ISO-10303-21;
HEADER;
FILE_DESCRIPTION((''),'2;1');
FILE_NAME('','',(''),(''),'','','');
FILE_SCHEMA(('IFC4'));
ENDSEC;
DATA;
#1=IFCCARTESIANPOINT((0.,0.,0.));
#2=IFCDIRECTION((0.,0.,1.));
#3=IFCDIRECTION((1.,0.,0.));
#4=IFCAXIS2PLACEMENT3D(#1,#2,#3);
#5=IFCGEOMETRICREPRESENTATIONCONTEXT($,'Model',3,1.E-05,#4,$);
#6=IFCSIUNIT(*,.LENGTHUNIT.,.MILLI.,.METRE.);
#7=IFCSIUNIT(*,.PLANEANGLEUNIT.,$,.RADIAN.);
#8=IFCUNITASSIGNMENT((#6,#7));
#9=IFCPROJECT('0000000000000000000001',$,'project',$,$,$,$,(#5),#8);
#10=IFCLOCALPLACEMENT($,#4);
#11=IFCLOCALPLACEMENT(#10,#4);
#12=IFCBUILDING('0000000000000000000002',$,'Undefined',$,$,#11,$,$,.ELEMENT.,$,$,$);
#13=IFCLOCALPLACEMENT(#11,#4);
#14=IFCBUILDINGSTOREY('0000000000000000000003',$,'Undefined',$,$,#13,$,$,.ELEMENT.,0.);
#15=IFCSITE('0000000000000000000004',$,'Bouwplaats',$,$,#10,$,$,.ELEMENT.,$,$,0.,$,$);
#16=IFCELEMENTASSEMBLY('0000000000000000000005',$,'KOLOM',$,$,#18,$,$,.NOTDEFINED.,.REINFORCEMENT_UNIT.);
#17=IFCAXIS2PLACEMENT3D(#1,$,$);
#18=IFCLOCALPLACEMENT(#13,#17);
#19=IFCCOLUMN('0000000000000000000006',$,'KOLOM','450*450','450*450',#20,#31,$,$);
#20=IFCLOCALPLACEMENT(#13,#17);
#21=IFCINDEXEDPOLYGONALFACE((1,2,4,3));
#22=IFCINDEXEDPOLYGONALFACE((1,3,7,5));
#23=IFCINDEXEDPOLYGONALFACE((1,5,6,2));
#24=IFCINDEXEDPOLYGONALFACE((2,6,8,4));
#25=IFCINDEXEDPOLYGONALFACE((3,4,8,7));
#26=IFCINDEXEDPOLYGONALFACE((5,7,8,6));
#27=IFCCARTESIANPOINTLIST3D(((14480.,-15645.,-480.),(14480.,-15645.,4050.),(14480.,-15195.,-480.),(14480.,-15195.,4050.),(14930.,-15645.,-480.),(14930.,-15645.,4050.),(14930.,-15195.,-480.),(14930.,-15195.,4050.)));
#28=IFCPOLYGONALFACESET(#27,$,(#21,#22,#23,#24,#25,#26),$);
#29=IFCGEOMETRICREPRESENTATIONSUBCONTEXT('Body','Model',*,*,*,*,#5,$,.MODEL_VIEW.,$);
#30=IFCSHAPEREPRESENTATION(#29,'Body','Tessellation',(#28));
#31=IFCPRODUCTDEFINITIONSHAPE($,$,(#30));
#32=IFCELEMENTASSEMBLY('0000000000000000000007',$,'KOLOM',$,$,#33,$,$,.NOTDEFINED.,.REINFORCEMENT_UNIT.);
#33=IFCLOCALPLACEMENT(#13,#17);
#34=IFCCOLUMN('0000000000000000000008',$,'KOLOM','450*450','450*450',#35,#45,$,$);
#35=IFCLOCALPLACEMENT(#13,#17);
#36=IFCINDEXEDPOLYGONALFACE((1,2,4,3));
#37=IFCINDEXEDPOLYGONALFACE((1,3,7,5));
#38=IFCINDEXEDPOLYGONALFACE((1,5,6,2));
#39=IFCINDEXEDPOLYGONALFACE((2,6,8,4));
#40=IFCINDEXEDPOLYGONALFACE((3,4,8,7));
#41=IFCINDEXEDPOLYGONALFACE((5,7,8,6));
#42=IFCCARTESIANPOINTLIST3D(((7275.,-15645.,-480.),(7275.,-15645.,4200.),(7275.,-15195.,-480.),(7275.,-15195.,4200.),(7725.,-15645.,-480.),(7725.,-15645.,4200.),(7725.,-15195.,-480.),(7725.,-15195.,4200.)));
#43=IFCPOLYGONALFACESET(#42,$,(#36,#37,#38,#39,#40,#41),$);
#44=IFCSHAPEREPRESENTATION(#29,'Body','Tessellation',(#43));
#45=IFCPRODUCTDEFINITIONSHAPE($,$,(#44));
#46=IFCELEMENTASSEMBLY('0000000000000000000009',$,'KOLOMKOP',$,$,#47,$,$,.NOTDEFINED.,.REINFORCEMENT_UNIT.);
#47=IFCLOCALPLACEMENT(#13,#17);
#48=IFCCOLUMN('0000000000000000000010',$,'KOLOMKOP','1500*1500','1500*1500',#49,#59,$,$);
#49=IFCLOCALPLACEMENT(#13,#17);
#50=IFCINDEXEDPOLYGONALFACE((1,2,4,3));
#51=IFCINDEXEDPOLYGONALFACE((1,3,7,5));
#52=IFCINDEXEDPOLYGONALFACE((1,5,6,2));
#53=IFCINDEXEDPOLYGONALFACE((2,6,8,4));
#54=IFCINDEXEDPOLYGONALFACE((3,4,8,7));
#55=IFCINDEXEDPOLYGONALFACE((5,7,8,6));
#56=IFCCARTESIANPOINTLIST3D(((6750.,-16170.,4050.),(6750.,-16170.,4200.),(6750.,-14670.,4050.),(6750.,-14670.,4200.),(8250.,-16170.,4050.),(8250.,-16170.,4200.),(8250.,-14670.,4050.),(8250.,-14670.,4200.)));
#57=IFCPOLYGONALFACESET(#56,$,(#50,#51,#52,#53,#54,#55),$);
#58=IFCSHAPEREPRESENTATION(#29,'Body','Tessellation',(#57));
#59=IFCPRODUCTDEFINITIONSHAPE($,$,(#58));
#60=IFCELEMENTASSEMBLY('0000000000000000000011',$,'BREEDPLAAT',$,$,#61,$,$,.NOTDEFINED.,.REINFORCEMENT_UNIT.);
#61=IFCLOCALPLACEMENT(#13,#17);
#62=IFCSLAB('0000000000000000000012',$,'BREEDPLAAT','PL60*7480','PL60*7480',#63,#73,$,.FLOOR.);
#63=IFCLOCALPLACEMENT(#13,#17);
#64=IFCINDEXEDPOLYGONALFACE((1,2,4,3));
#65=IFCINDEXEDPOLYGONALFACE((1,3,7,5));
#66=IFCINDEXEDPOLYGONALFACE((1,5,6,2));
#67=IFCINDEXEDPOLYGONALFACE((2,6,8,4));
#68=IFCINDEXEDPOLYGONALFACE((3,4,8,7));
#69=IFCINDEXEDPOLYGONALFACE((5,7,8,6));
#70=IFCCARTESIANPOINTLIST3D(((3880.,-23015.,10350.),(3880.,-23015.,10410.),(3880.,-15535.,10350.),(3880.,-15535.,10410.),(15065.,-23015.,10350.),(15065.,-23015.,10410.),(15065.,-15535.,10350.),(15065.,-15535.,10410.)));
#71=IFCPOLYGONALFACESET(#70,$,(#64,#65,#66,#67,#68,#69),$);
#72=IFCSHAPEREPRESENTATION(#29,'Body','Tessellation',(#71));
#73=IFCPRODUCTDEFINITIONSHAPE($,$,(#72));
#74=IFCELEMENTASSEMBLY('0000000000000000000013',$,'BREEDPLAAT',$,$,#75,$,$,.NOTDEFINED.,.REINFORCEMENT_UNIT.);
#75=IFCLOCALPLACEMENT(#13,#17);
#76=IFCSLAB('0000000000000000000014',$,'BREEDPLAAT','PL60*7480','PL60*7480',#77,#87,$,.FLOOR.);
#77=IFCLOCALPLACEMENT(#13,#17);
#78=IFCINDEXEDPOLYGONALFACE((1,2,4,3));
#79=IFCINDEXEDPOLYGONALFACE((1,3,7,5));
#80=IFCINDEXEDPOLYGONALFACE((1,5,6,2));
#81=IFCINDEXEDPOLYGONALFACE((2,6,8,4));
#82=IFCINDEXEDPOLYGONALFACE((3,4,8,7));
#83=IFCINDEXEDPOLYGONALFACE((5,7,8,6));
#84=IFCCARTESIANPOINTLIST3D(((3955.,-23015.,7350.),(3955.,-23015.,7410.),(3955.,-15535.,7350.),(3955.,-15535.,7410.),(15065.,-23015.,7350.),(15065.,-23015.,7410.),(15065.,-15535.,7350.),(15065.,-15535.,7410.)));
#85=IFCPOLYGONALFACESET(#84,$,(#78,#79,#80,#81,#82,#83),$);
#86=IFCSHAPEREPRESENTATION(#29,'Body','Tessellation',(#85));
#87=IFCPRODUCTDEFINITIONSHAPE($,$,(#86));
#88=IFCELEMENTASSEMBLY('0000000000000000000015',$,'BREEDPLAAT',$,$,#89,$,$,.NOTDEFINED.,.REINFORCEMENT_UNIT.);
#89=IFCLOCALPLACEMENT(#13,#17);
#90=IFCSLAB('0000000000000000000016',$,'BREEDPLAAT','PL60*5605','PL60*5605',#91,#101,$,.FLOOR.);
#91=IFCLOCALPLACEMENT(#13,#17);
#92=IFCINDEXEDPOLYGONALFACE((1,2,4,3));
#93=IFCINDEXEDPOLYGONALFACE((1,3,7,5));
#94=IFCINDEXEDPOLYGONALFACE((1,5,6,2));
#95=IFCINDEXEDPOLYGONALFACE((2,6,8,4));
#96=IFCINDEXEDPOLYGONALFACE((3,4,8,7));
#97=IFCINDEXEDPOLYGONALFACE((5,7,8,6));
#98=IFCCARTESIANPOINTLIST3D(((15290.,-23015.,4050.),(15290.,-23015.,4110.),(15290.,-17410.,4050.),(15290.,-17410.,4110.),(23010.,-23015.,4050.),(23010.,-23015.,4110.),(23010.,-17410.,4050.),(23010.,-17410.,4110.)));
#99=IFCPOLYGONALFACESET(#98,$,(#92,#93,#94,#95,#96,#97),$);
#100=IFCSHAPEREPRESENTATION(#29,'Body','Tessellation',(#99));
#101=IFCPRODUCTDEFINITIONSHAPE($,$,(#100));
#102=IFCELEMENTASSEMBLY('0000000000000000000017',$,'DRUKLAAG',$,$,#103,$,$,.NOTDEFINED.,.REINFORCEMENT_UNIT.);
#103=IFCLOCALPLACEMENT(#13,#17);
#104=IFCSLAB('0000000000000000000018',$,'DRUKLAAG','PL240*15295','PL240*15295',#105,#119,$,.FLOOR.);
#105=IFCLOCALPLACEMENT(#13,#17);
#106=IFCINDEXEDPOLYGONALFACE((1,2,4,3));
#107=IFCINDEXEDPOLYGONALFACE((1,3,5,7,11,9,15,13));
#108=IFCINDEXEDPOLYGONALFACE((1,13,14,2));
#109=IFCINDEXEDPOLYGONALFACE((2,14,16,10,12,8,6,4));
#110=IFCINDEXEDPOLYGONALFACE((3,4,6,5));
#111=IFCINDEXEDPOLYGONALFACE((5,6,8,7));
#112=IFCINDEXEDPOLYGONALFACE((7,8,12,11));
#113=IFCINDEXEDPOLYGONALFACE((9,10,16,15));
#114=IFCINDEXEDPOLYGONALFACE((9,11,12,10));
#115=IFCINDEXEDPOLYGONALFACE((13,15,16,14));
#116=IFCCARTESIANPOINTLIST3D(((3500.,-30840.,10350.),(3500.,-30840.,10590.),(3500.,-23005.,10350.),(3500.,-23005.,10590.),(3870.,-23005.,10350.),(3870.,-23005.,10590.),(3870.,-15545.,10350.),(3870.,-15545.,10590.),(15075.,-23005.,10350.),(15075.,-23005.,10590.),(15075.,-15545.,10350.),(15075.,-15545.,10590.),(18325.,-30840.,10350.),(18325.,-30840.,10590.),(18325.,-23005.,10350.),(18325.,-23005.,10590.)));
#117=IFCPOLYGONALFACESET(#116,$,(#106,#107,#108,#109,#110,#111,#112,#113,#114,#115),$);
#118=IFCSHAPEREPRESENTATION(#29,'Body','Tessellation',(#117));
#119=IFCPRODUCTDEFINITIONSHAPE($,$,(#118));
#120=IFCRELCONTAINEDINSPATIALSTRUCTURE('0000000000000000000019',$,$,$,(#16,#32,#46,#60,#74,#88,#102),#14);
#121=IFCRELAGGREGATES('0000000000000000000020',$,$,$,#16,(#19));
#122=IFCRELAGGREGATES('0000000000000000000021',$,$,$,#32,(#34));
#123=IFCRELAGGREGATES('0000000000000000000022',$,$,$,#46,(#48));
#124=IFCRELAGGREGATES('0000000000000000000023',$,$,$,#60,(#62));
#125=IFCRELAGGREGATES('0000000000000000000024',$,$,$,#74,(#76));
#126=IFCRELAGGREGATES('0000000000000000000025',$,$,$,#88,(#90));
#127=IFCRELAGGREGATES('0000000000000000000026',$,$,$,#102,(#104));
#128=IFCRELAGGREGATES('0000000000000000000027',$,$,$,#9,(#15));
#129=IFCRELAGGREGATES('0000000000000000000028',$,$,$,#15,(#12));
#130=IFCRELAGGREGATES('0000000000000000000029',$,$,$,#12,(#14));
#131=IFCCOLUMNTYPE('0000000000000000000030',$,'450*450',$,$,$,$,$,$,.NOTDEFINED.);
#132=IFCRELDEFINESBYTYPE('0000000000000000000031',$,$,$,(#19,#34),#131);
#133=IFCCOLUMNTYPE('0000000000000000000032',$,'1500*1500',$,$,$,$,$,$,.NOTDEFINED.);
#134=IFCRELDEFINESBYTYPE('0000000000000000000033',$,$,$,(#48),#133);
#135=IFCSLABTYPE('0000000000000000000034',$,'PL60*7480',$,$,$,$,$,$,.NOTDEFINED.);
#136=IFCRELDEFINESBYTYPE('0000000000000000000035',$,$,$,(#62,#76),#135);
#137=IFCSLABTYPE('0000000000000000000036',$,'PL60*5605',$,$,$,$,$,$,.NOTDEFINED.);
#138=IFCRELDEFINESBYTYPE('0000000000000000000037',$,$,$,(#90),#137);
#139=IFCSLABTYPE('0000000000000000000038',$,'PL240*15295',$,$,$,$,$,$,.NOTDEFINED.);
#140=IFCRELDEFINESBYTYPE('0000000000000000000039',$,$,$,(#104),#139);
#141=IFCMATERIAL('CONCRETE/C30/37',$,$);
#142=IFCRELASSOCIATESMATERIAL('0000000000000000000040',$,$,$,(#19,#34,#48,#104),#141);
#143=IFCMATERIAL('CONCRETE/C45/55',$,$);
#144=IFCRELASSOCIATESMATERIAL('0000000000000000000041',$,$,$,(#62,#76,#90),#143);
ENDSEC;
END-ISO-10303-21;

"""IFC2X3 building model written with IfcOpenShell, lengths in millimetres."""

from ifc_helpers import new_model, si_unit, frame, origin_with_axes, origin_2d_with_axis, place, context, subcontext, project, spatial, polyline, rectangle, outline, extrude, material, type_object, element, aggregate, save


model = new_model("IFC2X3")

# Units and contexts
model_context = context("Model", 3, precision=1e-05, world=origin_with_axes())
body_context = subcontext(model_context, "Body", "Model", "MODEL_VIEW")
ifc_project = project(units=[si_unit("LENGTHUNIT", "METRE", prefix="MILLI"), si_unit("PLANEANGLEUNIT", "RADIAN")], contexts=[model_context])

# Site, building, storey
site_placement = place(None, origin_with_axes())
site = spatial("IfcSite", under=ifc_project, at=site_placement, Name="Bouwplaats", CompositionType="ELEMENT", RefElevation=0.0)
building_placement = place(site_placement, origin_with_axes())
building = spatial("IfcBuilding", under=site, at=building_placement, Name="Undefined", CompositionType="ELEMENT")
storey_placement = place(building_placement, origin_with_axes())
storey = spatial("IfcBuildingStorey", under=building, at=storey_placement, Name="Undefined", CompositionType="ELEMENT", Elevation=0.0)

# Shared definitions
ifc_material_1 = material(Name="CONCRETE/C30/37")

# Element assemblies, columns
assembly_1_placement = place(storey_placement, origin_with_axes())
assembly_1 = element("IfcElementAssembly", 1, at=assembly_1_placement, inside=storey, Name="KOLOM", AssemblyPlace="NOTDEFINED", PredefinedType="REINFORCEMENT_UNIT")
column_type_1 = type_object("IfcColumnType", Name="450*450", PredefinedType="NOTDEFINED")
column_1_placement = place(assembly_1_placement, frame((14705.0, -15420.0, -480.0), z_axis=(0.0, 0.0, 1.0), x_axis=(0.0, 1.0, 0.0)))
column_1 = element("IfcColumn", 2, at=column_1_placement, type_object=column_type_1, material=ifc_material_1, Name="KOLOM", Description="450*450", ObjectType="450*450", context=body_context, shape_type="SweptSolid", body=[
    extrude(rectangle(XDim=450.0, YDim=450.0, at=origin_2d_with_axis()), frame((0.0, 0.0, 4530.0), z_axis=(0.0, 0.0, -1.0), x_axis=(0.0, 1.0, 0.0)), (0.0, 0.0, 1.0), 4530.0),
])
aggregate(assembly_1, [column_1])
assembly_2_placement = place(storey_placement, origin_with_axes())
assembly_2 = element("IfcElementAssembly", 3, at=assembly_2_placement, inside=storey, Name="KOLOM", AssemblyPlace="NOTDEFINED", PredefinedType="REINFORCEMENT_UNIT")
column_2_placement = place(assembly_2_placement, frame((7500.0, -15420.0, -480.0), z_axis=(0.0, 0.0, 1.0), x_axis=(0.0, 1.0, 0.0)))
column_2 = element("IfcColumn", 4, at=column_2_placement, type_object=column_type_1, material=ifc_material_1, Name="KOLOM", Description="450*450", ObjectType="450*450", context=body_context, shape_type="SweptSolid", body=[
    extrude(rectangle(XDim=450.0, YDim=450.0, at=origin_2d_with_axis()), frame((0.0, 0.0, 4680.0), z_axis=(0.0, 0.0, -1.0), x_axis=(0.0, 1.0, 0.0)), (0.0, 0.0, 1.0), 4680.0),
])
aggregate(assembly_2, [column_2])
assembly_3_placement = place(storey_placement, origin_with_axes())
assembly_3 = element("IfcElementAssembly", 5, at=assembly_3_placement, inside=storey, Name="KOLOMKOP", AssemblyPlace="NOTDEFINED", PredefinedType="REINFORCEMENT_UNIT")
column_type_2 = type_object("IfcColumnType", Name="1500*1500", PredefinedType="NOTDEFINED")
column_3_placement = place(assembly_3_placement, frame((7500.0, -15420.0, 4050.0), z_axis=(0.0, 0.0, 1.0), x_axis=(0.0, 1.0, 0.0)))
column_3 = element("IfcColumn", 6, at=column_3_placement, type_object=column_type_2, material=ifc_material_1, Name="KOLOMKOP", Description="1500*1500", ObjectType="1500*1500", context=body_context, shape_type="SweptSolid", body=[
    extrude(rectangle(XDim=1500.0, YDim=1500.0, at=origin_2d_with_axis()), frame((0.0, 0.0, 150.0), z_axis=(0.0, 0.0, -1.0), x_axis=(0.0, 1.0, 0.0)), (0.0, 0.0, 1.0), 150.0),
])
aggregate(assembly_3, [column_3])

# Element assemblies, slabs
assembly_4_placement = place(storey_placement, origin_with_axes())
assembly_4 = element("IfcElementAssembly", 7, at=assembly_4_placement, inside=storey, Name="BREEDPLAAT", AssemblyPlace="NOTDEFINED", PredefinedType="REINFORCEMENT_UNIT")
ifc_material_2 = material(Name="CONCRETE/C45/55")
slab_type_1 = type_object("IfcSlabType", Name="PL60*7480", PredefinedType="NOTDEFINED")
slab_1_placement = place(assembly_4_placement, frame((15065.0, -15535.0, 10380.0), z_axis=(0.0, 0.0, 1.0), x_axis=(-1.0, 0.0, 0.0)))
slab_1 = element("IfcSlab", 8, at=slab_1_placement, type_object=slab_type_1, material=ifc_material_2, Name="BREEDPLAAT", Description="PL60*7480", ObjectType="PL60*7480", PredefinedType="FLOOR", context=body_context, shape_type="SweptSolid", body=[
    extrude(outline(polyline([(0.0, 0.0), (11185.0, 0.0), (11185.0, 7480.0), (0.0, 7480.0), (0.0, 0.0)])), frame((0.0, 0.0, -30.0), z_axis=(0.0, 0.0, 1.0), x_axis=(1.0, 0.0, 0.0)), (0.0, 0.0, 1.0), 60.0),
])
aggregate(assembly_4, [slab_1])
assembly_5_placement = place(storey_placement, origin_with_axes())
assembly_5 = element("IfcElementAssembly", 9, at=assembly_5_placement, inside=storey, Name="BREEDPLAAT", AssemblyPlace="NOTDEFINED", PredefinedType="REINFORCEMENT_UNIT")
slab_2_placement = place(assembly_5_placement, frame((15065.0, -15535.0, 7380.0), z_axis=(0.0, 0.0, 1.0), x_axis=(-1.0, 0.0, 0.0)))
slab_2 = element("IfcSlab", 10, at=slab_2_placement, type_object=slab_type_1, material=ifc_material_2, Name="BREEDPLAAT", Description="PL60*7480", ObjectType="PL60*7480", PredefinedType="FLOOR", context=body_context, shape_type="SweptSolid", body=[
    extrude(outline(polyline([(0.0, 0.0), (11110.0, 0.0), (11110.0, 7480.0), (0.0, 7480.0), (0.0, 0.0)])), frame((0.0, 0.0, -30.0), z_axis=(0.0, 0.0, 1.0), x_axis=(1.0, 0.0, 0.0)), (0.0, 0.0, 1.0), 60.0),
])
aggregate(assembly_5, [slab_2])
assembly_6_placement = place(storey_placement, origin_with_axes())
assembly_6 = element("IfcElementAssembly", 11, at=assembly_6_placement, inside=storey, Name="BREEDPLAAT", AssemblyPlace="NOTDEFINED", PredefinedType="REINFORCEMENT_UNIT")
slab_type_2 = type_object("IfcSlabType", Name="PL60*5605", PredefinedType="NOTDEFINED")
slab_3_placement = place(assembly_6_placement, frame((15290.0, -17410.0, 4080.0), z_axis=(0.0, 0.0, 1.0), x_axis=(0.0, -1.0, 0.0)))
slab_3 = element("IfcSlab", 12, at=slab_3_placement, type_object=slab_type_2, material=ifc_material_2, Name="BREEDPLAAT", Description="PL60*5605", ObjectType="PL60*5605", PredefinedType="FLOOR", context=body_context, shape_type="SweptSolid", body=[
    extrude(outline(polyline([(0.0, 0.0), (5605.0, 0.0), (5605.0, 7720.0), (0.0, 7720.0), (0.0, 0.0)])), frame((0.0, 0.0, -30.0), z_axis=(0.0, 0.0, 1.0), x_axis=(1.0, 0.0, 0.0)), (0.0, 0.0, 1.0), 60.0),
])
aggregate(assembly_6, [slab_3])
assembly_7_placement = place(storey_placement, origin_with_axes())
assembly_7 = element("IfcElementAssembly", 13, at=assembly_7_placement, inside=storey, Name="DRUKLAAG", AssemblyPlace="NOTDEFINED", PredefinedType="REINFORCEMENT_UNIT")
slab_type_3 = type_object("IfcSlabType", Name="PL240*15295", PredefinedType="NOTDEFINED")
slab_4_placement = place(assembly_7_placement, frame((15075.0, -23005.0, 10470.0), z_axis=(0.0, 0.0, 1.0), x_axis=(0.0, 1.0, 0.0)))
slab_4 = element("IfcSlab", 14, at=slab_4_placement, type_object=slab_type_3, material=ifc_material_1, Name="DRUKLAAG", Description="PL240*15295", ObjectType="PL240*15295", PredefinedType="FLOOR", context=body_context, shape_type="SweptSolid", body=[
    extrude(outline(polyline([(0.0, 0.0), (7460.0, 0.0), (7460.0, 11205.0), (0.0, 11205.0), (0.0, 11575.0), (-7835.0, 11575.0), (-7835.0, -3250.0), (0.0, -3250.0), (0.0, 0.0)])), frame((0.0, 0.0, -120.0), z_axis=(0.0, 0.0, 1.0), x_axis=(1.0, 0.0, 0.0)), (0.0, 0.0, 1.0), 240.0),
])
aggregate(assembly_7, [slab_4])

save(model, "model.ifc")
